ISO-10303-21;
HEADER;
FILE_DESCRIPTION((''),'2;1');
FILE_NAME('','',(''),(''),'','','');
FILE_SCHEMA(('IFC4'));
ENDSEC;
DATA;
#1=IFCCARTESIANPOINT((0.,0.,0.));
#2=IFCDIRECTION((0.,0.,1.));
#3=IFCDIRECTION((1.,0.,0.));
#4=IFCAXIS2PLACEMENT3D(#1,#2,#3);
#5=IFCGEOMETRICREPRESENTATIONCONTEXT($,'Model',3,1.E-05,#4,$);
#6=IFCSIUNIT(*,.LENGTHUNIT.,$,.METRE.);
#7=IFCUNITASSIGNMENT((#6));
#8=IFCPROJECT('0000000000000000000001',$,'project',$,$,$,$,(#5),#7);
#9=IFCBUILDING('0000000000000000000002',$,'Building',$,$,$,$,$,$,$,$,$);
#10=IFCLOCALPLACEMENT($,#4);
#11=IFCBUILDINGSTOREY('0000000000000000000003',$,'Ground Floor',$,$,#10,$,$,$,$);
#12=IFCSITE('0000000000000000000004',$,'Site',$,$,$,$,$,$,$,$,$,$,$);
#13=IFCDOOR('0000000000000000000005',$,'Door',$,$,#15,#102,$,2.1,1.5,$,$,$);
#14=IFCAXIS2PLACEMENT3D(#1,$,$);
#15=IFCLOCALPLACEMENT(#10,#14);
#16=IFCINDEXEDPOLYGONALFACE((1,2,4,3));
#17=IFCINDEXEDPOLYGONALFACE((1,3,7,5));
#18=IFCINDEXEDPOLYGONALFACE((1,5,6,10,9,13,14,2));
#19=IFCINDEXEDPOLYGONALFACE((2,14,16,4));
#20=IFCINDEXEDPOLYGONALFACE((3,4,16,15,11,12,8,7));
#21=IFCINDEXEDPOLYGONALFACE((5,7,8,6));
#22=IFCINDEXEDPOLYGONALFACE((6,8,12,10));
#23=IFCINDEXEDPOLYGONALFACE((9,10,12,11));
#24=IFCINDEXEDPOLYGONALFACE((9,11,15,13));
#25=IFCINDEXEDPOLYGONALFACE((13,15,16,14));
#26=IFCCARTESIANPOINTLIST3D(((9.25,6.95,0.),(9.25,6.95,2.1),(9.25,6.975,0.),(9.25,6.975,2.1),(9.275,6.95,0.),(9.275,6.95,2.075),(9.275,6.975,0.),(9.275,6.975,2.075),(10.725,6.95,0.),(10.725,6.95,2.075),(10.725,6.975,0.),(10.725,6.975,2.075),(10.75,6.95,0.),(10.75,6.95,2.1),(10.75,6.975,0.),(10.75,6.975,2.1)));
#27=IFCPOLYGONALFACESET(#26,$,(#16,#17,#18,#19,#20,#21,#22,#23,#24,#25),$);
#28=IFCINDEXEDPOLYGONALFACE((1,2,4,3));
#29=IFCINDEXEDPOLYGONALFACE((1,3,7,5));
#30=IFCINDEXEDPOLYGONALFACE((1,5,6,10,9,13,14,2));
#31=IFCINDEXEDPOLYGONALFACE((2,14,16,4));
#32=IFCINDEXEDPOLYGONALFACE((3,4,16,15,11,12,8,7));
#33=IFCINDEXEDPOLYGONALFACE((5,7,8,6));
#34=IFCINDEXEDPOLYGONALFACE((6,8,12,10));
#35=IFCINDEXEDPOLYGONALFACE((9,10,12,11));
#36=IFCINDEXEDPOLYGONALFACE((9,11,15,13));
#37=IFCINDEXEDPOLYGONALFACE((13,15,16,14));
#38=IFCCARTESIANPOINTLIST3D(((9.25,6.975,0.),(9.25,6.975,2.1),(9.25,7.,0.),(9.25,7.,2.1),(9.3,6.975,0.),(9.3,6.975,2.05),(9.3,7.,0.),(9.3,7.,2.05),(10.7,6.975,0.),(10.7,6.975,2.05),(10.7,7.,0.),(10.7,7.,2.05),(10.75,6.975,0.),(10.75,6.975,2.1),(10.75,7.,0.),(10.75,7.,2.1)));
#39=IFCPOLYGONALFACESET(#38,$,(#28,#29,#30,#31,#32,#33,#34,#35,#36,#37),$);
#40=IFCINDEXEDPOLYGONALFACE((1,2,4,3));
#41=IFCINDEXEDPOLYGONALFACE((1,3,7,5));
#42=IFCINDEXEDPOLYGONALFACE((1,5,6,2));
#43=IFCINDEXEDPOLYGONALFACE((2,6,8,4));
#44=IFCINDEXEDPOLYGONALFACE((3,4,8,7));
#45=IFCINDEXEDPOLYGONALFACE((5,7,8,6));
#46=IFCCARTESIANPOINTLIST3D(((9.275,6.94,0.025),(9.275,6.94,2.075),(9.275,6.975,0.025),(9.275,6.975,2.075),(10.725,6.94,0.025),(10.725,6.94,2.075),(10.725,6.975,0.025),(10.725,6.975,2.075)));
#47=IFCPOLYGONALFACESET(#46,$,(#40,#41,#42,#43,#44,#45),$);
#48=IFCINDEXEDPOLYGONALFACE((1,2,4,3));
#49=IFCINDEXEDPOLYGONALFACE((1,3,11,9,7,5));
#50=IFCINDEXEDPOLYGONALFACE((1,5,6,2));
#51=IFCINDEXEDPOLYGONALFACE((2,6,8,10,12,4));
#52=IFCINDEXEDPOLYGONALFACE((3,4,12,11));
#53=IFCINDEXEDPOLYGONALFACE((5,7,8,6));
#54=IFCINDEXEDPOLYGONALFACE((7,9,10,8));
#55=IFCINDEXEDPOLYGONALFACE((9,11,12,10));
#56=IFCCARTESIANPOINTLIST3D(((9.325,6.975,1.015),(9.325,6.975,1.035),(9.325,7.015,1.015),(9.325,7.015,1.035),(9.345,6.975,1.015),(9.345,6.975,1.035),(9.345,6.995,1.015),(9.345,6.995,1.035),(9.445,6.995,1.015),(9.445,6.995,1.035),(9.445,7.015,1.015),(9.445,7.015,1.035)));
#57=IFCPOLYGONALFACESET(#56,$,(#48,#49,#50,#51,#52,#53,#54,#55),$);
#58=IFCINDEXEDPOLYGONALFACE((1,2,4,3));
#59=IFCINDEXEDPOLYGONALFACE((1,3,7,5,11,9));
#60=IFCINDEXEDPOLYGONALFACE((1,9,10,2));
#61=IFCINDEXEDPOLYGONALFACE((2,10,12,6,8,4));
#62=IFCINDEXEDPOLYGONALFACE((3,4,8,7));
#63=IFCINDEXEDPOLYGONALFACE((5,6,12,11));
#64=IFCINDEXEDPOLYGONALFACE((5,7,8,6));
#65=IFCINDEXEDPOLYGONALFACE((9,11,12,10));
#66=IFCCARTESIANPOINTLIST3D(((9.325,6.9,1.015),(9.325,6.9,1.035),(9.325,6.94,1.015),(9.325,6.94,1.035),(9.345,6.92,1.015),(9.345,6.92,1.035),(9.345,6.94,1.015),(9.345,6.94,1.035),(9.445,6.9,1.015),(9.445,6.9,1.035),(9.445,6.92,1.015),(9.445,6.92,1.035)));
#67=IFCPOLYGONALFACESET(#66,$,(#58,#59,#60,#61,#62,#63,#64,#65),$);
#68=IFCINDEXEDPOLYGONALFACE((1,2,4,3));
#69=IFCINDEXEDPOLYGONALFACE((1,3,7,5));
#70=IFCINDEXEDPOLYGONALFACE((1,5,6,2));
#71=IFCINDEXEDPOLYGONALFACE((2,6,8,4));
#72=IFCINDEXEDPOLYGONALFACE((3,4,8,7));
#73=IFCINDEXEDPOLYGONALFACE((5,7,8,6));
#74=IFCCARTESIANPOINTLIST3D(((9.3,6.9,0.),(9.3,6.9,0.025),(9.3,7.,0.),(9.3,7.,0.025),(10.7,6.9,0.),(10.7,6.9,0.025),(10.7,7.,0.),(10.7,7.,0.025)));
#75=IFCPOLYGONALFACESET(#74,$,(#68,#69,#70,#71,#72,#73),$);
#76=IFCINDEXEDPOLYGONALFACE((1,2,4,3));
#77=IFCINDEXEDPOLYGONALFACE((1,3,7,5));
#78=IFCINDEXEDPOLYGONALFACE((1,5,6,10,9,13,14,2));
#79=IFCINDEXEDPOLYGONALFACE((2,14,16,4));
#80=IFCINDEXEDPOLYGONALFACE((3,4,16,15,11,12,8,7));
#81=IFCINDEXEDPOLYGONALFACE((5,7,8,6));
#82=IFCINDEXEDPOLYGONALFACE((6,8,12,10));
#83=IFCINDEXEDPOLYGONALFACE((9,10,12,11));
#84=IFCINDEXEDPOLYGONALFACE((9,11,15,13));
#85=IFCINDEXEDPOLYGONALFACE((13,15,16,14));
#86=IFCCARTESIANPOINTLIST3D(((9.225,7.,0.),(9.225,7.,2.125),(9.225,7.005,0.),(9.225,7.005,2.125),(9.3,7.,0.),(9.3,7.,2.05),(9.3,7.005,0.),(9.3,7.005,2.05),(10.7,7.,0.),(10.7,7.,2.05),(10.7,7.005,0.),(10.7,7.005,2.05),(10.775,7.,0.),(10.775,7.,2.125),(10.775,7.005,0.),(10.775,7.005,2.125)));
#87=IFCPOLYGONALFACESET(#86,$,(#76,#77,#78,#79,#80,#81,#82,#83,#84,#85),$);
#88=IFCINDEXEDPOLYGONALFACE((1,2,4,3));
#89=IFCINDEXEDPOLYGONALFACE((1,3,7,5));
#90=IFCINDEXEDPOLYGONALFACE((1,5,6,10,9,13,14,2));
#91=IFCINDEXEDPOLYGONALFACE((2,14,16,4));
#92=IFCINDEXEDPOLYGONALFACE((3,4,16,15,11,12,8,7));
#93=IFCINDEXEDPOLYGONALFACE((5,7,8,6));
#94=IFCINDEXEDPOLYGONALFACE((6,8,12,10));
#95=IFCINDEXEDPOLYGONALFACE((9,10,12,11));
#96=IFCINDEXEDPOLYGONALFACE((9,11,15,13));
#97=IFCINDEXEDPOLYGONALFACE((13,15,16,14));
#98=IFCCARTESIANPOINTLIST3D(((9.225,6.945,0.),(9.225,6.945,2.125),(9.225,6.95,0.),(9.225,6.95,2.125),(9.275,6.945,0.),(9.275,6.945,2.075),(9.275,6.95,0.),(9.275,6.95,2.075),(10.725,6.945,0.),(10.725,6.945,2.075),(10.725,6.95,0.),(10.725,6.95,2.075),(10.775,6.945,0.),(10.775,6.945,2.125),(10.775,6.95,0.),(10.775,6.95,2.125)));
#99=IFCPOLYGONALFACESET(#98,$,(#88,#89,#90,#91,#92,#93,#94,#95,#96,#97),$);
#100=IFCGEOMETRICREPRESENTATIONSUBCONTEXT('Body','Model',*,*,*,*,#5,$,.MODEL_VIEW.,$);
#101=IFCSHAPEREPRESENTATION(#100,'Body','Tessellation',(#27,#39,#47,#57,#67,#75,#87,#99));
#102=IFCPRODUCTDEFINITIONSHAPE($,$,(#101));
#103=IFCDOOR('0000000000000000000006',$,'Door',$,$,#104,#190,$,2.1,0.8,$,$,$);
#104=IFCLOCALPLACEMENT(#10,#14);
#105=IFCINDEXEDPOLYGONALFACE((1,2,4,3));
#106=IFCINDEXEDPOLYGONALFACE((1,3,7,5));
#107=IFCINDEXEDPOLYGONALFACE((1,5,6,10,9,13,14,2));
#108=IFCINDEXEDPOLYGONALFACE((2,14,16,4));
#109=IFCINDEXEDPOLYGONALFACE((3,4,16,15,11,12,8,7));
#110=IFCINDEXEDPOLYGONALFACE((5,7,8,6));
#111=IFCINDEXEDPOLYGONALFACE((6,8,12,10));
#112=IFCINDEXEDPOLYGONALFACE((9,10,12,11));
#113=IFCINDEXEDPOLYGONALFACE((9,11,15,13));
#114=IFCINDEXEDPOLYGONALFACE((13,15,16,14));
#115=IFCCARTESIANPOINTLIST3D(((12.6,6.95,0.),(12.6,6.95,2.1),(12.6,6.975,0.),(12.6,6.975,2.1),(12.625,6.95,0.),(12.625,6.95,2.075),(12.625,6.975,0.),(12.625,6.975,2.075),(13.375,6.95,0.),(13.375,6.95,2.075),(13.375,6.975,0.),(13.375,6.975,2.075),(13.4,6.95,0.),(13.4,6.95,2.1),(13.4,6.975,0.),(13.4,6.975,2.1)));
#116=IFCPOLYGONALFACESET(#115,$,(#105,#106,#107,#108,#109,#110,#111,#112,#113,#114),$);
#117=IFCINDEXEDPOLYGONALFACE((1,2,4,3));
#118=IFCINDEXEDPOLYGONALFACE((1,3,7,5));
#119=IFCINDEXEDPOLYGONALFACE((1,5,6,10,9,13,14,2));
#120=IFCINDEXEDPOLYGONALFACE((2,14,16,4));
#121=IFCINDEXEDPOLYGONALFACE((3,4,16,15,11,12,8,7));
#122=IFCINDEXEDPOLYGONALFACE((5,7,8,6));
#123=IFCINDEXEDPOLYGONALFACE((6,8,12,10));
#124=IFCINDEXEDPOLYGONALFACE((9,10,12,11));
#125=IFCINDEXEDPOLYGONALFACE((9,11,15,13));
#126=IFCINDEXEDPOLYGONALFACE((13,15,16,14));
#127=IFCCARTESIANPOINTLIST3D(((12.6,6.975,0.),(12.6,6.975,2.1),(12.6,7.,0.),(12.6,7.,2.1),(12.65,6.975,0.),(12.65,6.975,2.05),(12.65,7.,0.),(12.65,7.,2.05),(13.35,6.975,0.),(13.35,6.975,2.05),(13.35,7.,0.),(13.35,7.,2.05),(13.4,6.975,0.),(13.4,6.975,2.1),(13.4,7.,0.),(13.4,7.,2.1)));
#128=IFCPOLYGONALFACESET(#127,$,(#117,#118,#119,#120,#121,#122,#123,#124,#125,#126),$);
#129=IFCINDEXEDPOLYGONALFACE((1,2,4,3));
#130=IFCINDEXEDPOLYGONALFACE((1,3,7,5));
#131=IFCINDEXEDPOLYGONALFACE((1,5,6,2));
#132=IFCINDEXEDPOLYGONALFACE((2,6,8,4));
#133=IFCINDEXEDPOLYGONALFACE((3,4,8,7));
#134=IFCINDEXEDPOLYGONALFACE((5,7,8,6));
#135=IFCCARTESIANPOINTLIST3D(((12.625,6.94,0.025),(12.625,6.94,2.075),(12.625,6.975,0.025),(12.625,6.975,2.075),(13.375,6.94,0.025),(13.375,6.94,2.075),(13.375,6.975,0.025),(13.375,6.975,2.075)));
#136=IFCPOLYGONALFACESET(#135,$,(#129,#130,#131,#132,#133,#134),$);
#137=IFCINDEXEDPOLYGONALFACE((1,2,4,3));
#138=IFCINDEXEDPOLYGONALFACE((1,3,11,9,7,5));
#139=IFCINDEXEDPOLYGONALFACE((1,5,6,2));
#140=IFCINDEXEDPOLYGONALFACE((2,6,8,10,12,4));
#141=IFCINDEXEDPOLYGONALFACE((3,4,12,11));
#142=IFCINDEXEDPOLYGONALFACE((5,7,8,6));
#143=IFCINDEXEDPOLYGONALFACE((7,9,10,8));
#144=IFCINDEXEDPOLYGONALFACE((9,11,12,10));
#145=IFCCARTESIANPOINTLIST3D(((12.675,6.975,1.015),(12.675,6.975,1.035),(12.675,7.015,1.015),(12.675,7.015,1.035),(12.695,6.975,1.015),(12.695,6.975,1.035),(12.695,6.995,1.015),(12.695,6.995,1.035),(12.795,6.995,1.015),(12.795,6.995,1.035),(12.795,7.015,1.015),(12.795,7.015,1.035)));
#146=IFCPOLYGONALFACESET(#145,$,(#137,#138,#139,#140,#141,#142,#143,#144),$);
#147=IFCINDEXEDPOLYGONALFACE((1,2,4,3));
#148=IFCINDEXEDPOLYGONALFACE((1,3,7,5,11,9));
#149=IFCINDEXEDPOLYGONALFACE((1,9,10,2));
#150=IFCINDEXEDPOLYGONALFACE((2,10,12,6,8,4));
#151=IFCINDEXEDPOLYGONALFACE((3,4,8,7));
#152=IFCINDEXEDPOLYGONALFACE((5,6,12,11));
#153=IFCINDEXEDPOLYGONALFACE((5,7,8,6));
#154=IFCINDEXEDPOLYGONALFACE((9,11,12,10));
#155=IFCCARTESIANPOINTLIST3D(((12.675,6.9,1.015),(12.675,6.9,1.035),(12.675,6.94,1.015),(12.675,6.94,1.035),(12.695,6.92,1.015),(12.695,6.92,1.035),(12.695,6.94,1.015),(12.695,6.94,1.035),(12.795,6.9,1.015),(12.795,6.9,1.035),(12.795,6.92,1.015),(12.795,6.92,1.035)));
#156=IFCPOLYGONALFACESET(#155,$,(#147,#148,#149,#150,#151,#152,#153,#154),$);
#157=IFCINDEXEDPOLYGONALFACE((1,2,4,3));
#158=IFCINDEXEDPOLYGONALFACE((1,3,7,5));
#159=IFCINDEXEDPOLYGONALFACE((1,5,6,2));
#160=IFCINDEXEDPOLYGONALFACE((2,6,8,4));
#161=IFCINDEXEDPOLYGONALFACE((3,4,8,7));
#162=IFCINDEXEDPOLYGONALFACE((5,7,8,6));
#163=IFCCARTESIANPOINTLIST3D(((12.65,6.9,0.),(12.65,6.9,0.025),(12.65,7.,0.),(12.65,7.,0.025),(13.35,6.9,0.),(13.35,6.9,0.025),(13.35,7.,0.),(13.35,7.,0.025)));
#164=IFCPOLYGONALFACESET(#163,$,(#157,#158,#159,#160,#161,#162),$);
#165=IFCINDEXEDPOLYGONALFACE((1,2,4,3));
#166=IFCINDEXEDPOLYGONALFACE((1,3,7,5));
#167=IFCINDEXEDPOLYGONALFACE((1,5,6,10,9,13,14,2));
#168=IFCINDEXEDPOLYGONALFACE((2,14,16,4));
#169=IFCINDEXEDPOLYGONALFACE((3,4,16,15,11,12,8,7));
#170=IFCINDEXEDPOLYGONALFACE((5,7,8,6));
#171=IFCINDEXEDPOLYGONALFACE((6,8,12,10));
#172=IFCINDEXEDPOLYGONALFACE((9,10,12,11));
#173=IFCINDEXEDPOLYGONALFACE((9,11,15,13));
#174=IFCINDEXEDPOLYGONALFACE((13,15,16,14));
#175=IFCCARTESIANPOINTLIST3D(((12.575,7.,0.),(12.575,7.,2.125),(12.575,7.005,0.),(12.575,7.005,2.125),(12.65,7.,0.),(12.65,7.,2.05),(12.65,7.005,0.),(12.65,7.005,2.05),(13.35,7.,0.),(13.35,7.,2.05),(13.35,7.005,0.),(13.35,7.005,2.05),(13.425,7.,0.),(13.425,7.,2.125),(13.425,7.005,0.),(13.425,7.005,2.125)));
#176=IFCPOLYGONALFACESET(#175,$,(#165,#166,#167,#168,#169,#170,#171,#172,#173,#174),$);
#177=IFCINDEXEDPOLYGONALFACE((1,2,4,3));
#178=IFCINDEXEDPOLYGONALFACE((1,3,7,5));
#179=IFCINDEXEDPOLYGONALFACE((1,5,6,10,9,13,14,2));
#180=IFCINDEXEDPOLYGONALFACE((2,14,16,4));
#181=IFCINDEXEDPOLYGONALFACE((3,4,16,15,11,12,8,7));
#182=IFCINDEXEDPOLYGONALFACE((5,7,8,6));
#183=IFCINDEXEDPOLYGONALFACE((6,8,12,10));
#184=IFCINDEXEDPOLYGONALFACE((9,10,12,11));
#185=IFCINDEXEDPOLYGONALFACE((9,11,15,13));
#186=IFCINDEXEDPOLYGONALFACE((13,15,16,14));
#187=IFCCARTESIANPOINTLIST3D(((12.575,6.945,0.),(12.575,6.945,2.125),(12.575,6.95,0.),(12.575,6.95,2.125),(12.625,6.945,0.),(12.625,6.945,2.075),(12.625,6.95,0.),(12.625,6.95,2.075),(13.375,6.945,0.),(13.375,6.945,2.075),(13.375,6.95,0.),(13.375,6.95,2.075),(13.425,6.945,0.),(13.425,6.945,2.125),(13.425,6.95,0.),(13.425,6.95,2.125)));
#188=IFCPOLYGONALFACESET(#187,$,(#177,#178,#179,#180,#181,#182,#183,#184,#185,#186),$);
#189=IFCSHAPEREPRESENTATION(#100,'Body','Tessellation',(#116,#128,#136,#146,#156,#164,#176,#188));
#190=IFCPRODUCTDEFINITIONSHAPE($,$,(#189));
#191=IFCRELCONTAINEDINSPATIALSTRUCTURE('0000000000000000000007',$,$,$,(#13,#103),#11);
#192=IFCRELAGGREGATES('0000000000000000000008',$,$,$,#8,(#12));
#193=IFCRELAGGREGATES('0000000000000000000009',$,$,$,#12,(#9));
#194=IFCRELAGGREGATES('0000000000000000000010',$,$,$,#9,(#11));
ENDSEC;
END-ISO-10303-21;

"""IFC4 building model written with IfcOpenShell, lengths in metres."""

from ifc_helpers import new_model, si_unit, frame, origin_with_axes, place, context, subcontext, project, spatial, line, indexed_curve, outline, extrude, element, save


model = new_model("IFC4")

# Units and contexts
model_context = context("Model", 3, precision=1e-05, world=origin_with_axes())
body_context = subcontext(model_context, "Body", "Model", "MODEL_VIEW")
ifc_project = project(units=[si_unit("LENGTHUNIT", "METRE")], contexts=[model_context])

# Site, building, storey
site = spatial("IfcSite", under=ifc_project, Name="Site")
building = spatial("IfcBuilding", under=site, Name="Building")
storey_placement = place(None, origin_with_axes())
storey = spatial("IfcBuildingStorey", under=building, at=storey_placement, Name="Ground Floor")

# Doors
door_1_placement = place(storey_placement, frame((10.75, 7.0, 0.0), z_axis=(0.0, 0.0, 1.0), x_axis=(-1.0, 0.0, 0.0)))
element("IfcDoor", 1, at=door_1_placement, inside=storey, Name="Door", OverallHeight=2.1, OverallWidth=1.5, context=body_context, shape_type="SweptSolid", body=[
    extrude(outline(indexed_curve([(0.0, 0.0), (0.0, 2.1), (1.5, 2.1), (1.5, 0.0), (1.475, 0.0), (1.475, 2.075), (0.025, 2.075), (0.025, 0.0)], segments=[line(1, 2, 3, 4, 5, 6, 7, 8, 1)])), frame((0.0, 0.025, 0.0), z_axis=(0.0, -1.0, 0.0), x_axis=(1.0, 0.0, 0.0)), (0.0, 0.0, -1.0), 0.025),
    extrude(outline(indexed_curve([(0.0, 0.0), (0.0, 2.1), (1.5, 2.1), (1.5, 0.0), (1.45, 0.0), (1.45, 2.05), (0.05, 2.05), (0.05, 0.0)], segments=[line(1, 2, 3, 4, 5, 6, 7, 8, 1)])), frame((0.0, 0.0, 0.0), z_axis=(0.0, -1.0, 0.0), x_axis=(1.0, 0.0, 0.0)), (0.0, 0.0, -1.0), 0.025),
    extrude(outline(indexed_curve([(0.0, 0.0), (1.45, 0.0), (1.45, 0.035), (0.0, 0.035)], segments=[line(1, 2, 3, 4, 1)])), frame((0.025, 0.025, 0.025), z_axis=(0.0, 0.0, 1.0), x_axis=(1.0, 0.0, 0.0)), (0.0, 0.0, 1.0), 2.05),
    extrude(outline(indexed_curve([(0.0, 0.0), (0.0, -0.04), (-0.12, -0.04), (-0.12, -0.02), (-0.02, -0.02), (-0.02, 0.0)], segments=[line(1, 2, 3, 4, 5, 6, 1)])), frame((1.425, 0.025, 1.015), z_axis=(0.0, 0.0, 1.0), x_axis=(1.0, 0.0, 0.0)), (0.0, 0.0, 1.0), 0.02),
    extrude(outline(indexed_curve([(0.0, 0.0), (0.0, 0.04), (-0.12, 0.04), (-0.12, 0.02), (-0.02, 0.02), (-0.02, 0.0)], segments=[line(1, 2, 3, 4, 5, 6, 1)])), frame((1.425, 0.06, 1.015), z_axis=(0.0, 0.0, 1.0), x_axis=(1.0, 0.0, 0.0)), (0.0, 0.0, 1.0), 0.02),
    extrude(outline(indexed_curve([(0.0, 0.0), (1.4, 0.0), (1.4, 0.1), (0.0, 0.1)], segments=[line(1, 2, 3, 4, 1)])), frame((0.05, 0.0, 0.0), z_axis=(0.0, 0.0, 1.0), x_axis=(1.0, 0.0, 0.0)), (0.0, 0.0, 1.0), 0.025),
    extrude(outline(indexed_curve([(0.0, 0.0), (0.0, 2.125), (1.55, 2.125), (1.55, 0.0), (1.475, 0.0), (1.475, 2.05), (0.075, 2.05), (0.075, 0.0)], segments=[line(1, 2, 3, 4, 5, 6, 7, 8, 1)])), frame((-0.025, -0.005, 0.0), z_axis=(0.0, -1.0, 0.0), x_axis=(1.0, 0.0, 0.0)), (0.0, 0.0, -1.0), 0.005),
    extrude(outline(indexed_curve([(0.0, 0.0), (0.0, 2.125), (1.55, 2.125), (1.55, 0.0), (1.5, 0.0), (1.5, 2.075), (0.05, 2.075), (0.05, 0.0)], segments=[line(1, 2, 3, 4, 5, 6, 7, 8, 1)])), frame((-0.025, 0.05, 0.0), z_axis=(0.0, -1.0, 0.0), x_axis=(1.0, 0.0, 0.0)), (0.0, 0.0, -1.0), 0.005),
])
door_2_placement = place(storey_placement, frame((13.4, 7.0, 0.0), z_axis=(0.0, 0.0, 1.0), x_axis=(-1.0, 0.0, 0.0)))
element("IfcDoor", 2, at=door_2_placement, inside=storey, Name="Door", OverallHeight=2.1, OverallWidth=0.8, context=body_context, shape_type="SweptSolid", body=[
    extrude(outline(indexed_curve([(0.0, 0.0), (0.0, 2.1), (0.8, 2.1), (0.8, 0.0), (0.775, 0.0), (0.775, 2.075), (0.025, 2.075), (0.025, 0.0)], segments=[line(1, 2, 3, 4, 5, 6, 7, 8, 1)])), frame((0.0, 0.025, 0.0), z_axis=(0.0, -1.0, 0.0), x_axis=(1.0, 0.0, 0.0)), (0.0, 0.0, -1.0), 0.025),
    extrude(outline(indexed_curve([(0.0, 0.0), (0.0, 2.1), (0.8, 2.1), (0.8, 0.0), (0.75, 0.0), (0.75, 2.05), (0.05, 2.05), (0.05, 0.0)], segments=[line(1, 2, 3, 4, 5, 6, 7, 8, 1)])), frame((0.0, 0.0, 0.0), z_axis=(0.0, -1.0, 0.0), x_axis=(1.0, 0.0, 0.0)), (0.0, 0.0, -1.0), 0.025),
    extrude(outline(indexed_curve([(0.0, 0.0), (0.75, 0.0), (0.75, 0.035), (0.0, 0.035)], segments=[line(1, 2, 3, 4, 1)])), frame((0.025, 0.025, 0.025), z_axis=(0.0, 0.0, 1.0), x_axis=(1.0, 0.0, 0.0)), (0.0, 0.0, 1.0), 2.05),
    extrude(outline(indexed_curve([(0.0, 0.0), (0.0, -0.04), (-0.12, -0.04), (-0.12, -0.02), (-0.02, -0.02), (-0.02, 0.0)], segments=[line(1, 2, 3, 4, 5, 6, 1)])), frame((0.725, 0.025, 1.015), z_axis=(0.0, 0.0, 1.0), x_axis=(1.0, 0.0, 0.0)), (0.0, 0.0, 1.0), 0.02),
    extrude(outline(indexed_curve([(0.0, 0.0), (0.0, 0.04), (-0.12, 0.04), (-0.12, 0.02), (-0.02, 0.02), (-0.02, 0.0)], segments=[line(1, 2, 3, 4, 5, 6, 1)])), frame((0.725, 0.06, 1.015), z_axis=(0.0, 0.0, 1.0), x_axis=(1.0, 0.0, 0.0)), (0.0, 0.0, 1.0), 0.02),
    extrude(outline(indexed_curve([(0.0, 0.0), (0.7, 0.0), (0.7, 0.1), (0.0, 0.1)], segments=[line(1, 2, 3, 4, 1)])), frame((0.05, 0.0, 0.0), z_axis=(0.0, 0.0, 1.0), x_axis=(1.0, 0.0, 0.0)), (0.0, 0.0, 1.0), 0.025),
    extrude(outline(indexed_curve([(0.0, 0.0), (0.0, 2.125), (0.85, 2.125), (0.85, 0.0), (0.775, 0.0), (0.775, 2.05), (0.075, 2.05), (0.075, 0.0)], segments=[line(1, 2, 3, 4, 5, 6, 7, 8, 1)])), frame((-0.025, -0.005, 0.0), z_axis=(0.0, -1.0, 0.0), x_axis=(1.0, 0.0, 0.0)), (0.0, 0.0, -1.0), 0.005),
    extrude(outline(indexed_curve([(0.0, 0.0), (0.0, 2.125), (0.85, 2.125), (0.85, 0.0), (0.8, 0.0), (0.8, 2.075), (0.05, 2.075), (0.05, 0.0)], segments=[line(1, 2, 3, 4, 5, 6, 7, 8, 1)])), frame((-0.025, 0.05, 0.0), z_axis=(0.0, -1.0, 0.0), x_axis=(1.0, 0.0, 0.0)), (0.0, 0.0, -1.0), 0.005),
])

save(model, "model.ifc")
